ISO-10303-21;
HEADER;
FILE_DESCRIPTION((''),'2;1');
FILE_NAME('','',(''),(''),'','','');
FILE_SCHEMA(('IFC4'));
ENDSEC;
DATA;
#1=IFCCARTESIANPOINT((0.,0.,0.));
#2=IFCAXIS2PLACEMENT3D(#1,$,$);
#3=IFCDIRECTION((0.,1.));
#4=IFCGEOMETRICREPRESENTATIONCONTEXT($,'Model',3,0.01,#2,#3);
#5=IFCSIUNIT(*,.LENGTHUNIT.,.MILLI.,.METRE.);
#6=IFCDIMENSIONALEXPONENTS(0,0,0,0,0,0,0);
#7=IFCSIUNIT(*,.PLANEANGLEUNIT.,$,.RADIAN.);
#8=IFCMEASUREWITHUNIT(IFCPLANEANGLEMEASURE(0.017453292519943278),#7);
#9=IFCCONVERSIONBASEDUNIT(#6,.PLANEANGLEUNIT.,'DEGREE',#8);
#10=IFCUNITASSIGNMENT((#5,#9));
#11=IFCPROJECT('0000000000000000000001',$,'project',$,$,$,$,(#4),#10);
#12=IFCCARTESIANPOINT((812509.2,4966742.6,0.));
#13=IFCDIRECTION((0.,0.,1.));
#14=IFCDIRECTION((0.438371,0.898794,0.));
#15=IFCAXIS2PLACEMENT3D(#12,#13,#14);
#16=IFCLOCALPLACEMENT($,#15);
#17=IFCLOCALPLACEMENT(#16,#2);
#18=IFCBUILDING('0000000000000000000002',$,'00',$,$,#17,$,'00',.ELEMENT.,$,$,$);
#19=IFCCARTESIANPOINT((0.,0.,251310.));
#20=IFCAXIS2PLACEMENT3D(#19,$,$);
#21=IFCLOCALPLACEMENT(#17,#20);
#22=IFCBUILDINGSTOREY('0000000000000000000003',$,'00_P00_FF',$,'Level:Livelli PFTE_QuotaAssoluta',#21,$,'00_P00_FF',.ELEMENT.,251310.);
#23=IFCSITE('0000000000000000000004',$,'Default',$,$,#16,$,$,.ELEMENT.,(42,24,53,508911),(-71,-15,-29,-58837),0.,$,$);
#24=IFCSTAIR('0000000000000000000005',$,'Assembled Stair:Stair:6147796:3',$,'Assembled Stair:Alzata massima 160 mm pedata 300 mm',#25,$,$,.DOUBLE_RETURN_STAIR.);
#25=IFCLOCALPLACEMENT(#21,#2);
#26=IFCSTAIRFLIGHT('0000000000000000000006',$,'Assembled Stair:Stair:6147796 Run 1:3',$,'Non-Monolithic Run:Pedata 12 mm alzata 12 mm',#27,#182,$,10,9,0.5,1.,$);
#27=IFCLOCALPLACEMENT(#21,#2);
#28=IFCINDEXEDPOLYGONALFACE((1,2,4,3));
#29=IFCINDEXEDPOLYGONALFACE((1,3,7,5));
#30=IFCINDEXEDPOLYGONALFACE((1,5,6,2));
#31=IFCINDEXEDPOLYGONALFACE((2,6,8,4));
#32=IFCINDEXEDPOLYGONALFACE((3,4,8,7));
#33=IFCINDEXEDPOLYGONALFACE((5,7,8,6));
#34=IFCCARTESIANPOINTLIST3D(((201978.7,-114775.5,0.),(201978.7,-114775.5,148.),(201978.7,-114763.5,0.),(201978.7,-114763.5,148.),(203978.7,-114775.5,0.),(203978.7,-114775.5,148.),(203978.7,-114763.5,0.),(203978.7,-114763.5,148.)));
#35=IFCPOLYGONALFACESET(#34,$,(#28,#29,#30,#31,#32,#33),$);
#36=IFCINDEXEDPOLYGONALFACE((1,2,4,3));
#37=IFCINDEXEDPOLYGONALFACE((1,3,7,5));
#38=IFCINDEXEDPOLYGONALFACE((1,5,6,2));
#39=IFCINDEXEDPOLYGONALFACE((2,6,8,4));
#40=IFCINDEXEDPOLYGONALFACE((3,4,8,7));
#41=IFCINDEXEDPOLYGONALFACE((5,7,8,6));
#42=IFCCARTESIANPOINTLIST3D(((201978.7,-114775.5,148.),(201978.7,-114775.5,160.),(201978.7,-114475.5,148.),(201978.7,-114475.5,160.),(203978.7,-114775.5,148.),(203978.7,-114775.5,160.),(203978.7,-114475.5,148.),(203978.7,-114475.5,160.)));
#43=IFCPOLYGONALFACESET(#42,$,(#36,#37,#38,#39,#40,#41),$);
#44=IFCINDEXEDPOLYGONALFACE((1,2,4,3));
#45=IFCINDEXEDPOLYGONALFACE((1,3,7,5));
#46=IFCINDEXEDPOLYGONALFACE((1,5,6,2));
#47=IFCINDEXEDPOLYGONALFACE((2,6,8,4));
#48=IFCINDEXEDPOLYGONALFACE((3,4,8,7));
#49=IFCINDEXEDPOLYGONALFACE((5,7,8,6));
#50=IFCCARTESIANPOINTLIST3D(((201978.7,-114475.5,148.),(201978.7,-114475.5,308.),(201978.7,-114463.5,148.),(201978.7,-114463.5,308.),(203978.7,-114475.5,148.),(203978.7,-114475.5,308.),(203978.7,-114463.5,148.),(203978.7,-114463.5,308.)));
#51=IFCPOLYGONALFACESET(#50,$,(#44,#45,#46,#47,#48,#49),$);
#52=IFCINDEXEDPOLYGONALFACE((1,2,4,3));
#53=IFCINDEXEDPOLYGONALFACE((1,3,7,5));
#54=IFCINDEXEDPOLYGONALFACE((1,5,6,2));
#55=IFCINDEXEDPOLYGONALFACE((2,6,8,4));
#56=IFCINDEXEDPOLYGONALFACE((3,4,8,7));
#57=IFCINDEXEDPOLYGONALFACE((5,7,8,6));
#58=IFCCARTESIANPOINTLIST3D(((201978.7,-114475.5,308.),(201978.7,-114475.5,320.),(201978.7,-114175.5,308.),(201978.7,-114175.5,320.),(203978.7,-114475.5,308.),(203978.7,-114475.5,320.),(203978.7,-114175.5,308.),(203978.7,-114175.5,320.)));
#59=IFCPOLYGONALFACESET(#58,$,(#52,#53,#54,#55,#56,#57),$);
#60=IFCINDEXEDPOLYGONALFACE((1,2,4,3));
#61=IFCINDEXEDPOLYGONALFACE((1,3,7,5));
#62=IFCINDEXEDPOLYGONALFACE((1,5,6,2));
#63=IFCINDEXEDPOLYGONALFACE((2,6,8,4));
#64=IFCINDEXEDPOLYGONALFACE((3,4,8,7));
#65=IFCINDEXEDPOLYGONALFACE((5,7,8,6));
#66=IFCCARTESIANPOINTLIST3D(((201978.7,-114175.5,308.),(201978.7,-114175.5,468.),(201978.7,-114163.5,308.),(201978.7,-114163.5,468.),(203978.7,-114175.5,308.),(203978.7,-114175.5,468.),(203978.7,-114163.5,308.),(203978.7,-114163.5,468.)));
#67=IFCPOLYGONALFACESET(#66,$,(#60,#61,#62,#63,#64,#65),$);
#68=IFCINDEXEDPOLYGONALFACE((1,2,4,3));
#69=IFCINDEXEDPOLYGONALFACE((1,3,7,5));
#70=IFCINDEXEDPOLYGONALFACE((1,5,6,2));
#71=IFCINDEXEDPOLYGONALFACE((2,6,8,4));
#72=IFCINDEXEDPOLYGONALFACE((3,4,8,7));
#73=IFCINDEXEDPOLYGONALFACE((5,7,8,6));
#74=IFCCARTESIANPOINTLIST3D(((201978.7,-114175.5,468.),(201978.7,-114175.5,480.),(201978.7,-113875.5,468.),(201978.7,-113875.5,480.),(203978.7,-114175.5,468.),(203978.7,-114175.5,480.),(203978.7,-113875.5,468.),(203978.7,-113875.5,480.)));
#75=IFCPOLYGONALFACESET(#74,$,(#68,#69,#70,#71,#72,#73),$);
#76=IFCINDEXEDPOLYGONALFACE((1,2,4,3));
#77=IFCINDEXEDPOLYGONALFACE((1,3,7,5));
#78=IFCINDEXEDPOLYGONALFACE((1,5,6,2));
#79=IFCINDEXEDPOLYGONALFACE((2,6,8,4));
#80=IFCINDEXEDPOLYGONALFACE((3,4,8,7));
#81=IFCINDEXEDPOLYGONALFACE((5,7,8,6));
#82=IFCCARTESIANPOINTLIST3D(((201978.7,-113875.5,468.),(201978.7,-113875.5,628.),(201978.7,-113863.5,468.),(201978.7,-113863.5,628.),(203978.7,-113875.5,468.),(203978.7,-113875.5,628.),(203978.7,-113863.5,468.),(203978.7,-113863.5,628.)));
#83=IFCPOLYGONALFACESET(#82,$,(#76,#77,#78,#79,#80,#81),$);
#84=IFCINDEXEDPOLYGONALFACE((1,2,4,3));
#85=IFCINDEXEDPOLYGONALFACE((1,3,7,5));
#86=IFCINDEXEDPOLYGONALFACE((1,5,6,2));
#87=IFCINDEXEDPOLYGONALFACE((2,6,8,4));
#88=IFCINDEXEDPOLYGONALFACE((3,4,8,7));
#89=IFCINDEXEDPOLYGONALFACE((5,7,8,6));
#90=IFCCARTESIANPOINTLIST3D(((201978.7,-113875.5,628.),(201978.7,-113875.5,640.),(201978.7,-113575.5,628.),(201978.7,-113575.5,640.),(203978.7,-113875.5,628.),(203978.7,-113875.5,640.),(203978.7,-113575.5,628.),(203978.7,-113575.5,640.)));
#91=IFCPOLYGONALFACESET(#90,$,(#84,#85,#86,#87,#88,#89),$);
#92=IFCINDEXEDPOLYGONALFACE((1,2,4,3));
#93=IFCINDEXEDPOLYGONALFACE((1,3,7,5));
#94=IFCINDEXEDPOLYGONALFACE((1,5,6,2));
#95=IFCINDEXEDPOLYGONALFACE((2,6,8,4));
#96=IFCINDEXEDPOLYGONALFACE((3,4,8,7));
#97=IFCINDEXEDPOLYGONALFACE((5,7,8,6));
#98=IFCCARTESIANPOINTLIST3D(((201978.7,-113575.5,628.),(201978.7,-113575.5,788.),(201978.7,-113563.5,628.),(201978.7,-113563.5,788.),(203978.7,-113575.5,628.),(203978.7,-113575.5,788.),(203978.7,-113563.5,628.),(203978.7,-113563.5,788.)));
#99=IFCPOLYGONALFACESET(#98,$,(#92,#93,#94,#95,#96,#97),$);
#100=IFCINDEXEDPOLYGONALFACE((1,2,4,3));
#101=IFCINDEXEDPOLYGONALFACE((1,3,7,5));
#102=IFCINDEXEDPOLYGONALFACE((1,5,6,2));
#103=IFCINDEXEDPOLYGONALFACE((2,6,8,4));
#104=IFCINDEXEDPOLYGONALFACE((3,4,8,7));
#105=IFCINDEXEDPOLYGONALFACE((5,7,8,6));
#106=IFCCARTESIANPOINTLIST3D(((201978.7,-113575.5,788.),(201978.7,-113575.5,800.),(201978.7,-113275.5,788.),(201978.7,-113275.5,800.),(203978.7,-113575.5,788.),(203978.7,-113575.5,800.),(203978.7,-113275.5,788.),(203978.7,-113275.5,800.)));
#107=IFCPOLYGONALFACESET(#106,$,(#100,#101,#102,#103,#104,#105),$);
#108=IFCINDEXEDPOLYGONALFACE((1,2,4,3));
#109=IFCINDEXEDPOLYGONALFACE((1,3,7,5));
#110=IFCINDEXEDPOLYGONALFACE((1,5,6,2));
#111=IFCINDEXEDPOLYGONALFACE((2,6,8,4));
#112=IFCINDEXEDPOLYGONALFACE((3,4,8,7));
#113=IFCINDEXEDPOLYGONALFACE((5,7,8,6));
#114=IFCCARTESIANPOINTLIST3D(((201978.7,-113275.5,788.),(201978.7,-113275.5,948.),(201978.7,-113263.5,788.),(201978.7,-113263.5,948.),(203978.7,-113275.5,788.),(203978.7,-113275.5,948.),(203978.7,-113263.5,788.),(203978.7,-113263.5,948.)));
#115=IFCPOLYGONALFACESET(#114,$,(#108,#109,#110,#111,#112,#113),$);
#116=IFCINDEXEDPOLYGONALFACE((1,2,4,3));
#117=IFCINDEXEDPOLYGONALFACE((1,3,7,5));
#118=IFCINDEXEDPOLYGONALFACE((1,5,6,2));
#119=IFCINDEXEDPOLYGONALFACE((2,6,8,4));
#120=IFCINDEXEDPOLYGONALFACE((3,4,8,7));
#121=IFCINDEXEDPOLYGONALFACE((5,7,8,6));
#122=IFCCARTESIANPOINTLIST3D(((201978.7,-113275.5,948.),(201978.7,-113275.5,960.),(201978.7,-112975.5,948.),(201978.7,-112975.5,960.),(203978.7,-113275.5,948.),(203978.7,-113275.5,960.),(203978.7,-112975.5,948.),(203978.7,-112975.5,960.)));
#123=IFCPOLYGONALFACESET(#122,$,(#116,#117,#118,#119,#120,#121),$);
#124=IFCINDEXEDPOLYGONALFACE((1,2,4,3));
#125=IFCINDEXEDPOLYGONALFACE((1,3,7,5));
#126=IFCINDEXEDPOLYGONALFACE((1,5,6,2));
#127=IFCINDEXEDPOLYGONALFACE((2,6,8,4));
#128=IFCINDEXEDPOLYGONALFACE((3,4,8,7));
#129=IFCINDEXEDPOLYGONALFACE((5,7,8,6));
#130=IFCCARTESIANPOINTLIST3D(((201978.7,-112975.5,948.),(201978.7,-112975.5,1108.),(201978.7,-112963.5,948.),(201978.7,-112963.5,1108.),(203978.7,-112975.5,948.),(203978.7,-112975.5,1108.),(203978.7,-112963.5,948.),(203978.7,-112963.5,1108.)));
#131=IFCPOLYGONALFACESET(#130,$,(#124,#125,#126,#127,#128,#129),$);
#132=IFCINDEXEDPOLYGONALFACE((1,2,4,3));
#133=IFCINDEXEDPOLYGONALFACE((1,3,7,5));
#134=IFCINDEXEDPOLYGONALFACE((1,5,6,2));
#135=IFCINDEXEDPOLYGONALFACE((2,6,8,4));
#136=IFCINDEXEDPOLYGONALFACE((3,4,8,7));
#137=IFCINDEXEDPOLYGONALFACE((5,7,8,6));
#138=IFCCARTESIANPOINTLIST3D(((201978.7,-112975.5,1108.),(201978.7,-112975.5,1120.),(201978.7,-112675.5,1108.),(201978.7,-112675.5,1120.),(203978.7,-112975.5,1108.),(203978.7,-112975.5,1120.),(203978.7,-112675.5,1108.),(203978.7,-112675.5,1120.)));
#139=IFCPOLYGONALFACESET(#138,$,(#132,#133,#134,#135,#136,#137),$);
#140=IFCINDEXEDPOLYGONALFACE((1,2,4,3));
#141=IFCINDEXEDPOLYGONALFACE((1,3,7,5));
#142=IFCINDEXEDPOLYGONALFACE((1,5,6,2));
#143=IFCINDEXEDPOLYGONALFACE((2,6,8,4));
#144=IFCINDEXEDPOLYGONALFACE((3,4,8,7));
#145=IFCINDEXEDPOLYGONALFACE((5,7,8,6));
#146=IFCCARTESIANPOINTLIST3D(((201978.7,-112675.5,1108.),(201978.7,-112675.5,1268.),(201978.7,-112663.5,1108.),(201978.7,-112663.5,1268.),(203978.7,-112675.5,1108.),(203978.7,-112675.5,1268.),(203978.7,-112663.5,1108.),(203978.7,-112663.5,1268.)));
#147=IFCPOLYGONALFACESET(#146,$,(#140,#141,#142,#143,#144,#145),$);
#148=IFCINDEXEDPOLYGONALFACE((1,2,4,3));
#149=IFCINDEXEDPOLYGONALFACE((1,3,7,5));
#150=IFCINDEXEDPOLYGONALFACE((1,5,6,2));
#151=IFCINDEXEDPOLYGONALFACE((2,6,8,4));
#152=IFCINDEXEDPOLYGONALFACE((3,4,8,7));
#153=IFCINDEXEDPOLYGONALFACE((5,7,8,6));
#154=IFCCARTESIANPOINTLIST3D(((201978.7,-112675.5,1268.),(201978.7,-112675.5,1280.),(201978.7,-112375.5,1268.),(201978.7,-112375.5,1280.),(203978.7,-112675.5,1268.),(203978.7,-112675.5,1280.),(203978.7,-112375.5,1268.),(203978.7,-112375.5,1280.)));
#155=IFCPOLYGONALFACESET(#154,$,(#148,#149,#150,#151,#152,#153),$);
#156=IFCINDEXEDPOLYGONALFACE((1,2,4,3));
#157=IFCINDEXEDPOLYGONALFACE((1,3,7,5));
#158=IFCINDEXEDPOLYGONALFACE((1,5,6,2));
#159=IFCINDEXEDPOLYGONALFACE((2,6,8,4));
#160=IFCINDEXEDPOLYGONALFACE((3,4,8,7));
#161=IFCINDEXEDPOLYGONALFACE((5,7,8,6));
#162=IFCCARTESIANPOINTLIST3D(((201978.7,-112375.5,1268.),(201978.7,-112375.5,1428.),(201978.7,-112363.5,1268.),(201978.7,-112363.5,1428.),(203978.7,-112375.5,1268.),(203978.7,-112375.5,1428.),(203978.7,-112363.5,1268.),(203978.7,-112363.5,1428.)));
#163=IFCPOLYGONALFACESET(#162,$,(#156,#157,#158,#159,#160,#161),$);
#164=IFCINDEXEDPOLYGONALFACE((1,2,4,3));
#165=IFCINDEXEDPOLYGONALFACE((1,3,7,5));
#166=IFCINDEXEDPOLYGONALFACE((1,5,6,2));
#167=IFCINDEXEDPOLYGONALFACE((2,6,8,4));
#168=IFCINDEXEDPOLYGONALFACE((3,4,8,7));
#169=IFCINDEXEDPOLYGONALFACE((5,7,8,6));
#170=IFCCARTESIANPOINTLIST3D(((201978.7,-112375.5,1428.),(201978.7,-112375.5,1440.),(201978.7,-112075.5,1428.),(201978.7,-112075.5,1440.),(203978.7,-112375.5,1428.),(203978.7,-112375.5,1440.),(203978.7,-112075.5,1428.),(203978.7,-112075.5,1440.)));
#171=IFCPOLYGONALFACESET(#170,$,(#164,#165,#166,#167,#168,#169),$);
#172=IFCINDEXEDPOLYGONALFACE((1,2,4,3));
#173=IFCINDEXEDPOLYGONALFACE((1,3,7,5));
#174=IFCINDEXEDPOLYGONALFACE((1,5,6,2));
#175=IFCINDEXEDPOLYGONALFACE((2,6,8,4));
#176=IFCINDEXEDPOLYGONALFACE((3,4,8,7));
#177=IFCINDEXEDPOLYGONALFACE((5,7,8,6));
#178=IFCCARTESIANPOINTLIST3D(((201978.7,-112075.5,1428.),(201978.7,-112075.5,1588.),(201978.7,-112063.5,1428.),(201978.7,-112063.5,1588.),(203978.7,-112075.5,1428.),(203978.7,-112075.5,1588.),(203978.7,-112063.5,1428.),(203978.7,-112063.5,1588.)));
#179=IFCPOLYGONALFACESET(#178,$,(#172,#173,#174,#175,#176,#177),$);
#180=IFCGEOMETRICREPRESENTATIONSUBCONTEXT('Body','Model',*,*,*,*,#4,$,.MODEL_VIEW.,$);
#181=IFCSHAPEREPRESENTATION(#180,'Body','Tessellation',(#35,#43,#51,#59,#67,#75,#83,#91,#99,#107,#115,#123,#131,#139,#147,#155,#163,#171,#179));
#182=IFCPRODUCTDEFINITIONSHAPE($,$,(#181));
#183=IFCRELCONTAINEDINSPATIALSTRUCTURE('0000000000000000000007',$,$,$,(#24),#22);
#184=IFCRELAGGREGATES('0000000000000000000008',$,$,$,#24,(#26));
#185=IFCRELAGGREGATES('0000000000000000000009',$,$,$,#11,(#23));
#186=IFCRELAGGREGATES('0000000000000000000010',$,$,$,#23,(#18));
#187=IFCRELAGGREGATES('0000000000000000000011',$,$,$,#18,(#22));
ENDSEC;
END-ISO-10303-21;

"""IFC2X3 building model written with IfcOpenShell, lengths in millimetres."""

from ifc_helpers import new_model, entity, si_unit, converted_unit, direction, frame, frame_2d, origin, origin_2d_with_axis, place, context, subcontext, project, spatial, rectangle, extrude, element, aggregate, save


model = new_model("IFC2X3")

# Units and contexts
model_context = context("Model", 3, precision=0.01, world=origin(), true_north=direction((0.0, 1.0)))
body_context = subcontext(model_context, "Body", "Model", "MODEL_VIEW")
ifc_project = project(units=[si_unit("LENGTHUNIT", "METRE", prefix="MILLI"), converted_unit("PLANEANGLEUNIT", "DEGREE", entity("IfcPlaneAngleMeasure", 0.017453292519943278), si_unit("PLANEANGLEUNIT", "RADIAN"), dimensions=[0, 0, 0, 0, 0, 0, 0])], contexts=[model_context])

# Site, building, storey
site_placement = place(None, frame((812509.2, 4966742.6, 0.0), z_axis=(0.0, 0.0, 1.0), x_axis=(0.438371, 0.898794, 0.0)))
site = spatial("IfcSite", under=ifc_project, at=site_placement, Name="Default", CompositionType="ELEMENT", RefLatitude=(42, 24, 53, 508911), RefLongitude=(-71, -15, -29, -58837), RefElevation=0.0)
building_placement = place(site_placement, origin())
building = spatial("IfcBuilding", under=site, at=building_placement, Name="00", LongName="00", CompositionType="ELEMENT")
storey_placement = place(building_placement, frame((0.0, 0.0, 251310.0)))
storey = spatial("IfcBuildingStorey", under=building, at=storey_placement, Name="00_P00_FF", ObjectType="Level:Livelli PFTE_QuotaAssoluta", LongName="00_P00_FF", CompositionType="ELEMENT", Elevation=251310.0)

# Stair
stair_1_placement = place(storey_placement, origin())
stair_1 = element("IfcStair", 1, at=stair_1_placement, inside=storey, Name="Assembled Stair:Stair:6147796:3", ObjectType="Assembled Stair:Alzata massima 160 mm pedata 300 mm", ShapeType="DOUBLE_RETURN_STAIR")

# Stair flight
stair_flight_1_placement = place(stair_1_placement, origin())
stair_flight_1 = element("IfcStairFlight", 2, at=stair_flight_1_placement, Name="Assembled Stair:Stair:6147796 Run 1:3", ObjectType="Non-Monolithic Run:Pedata 12 mm alzata 12 mm", NumberOfRiser=10, NumberOfTreads=9, RiserHeight=0.5, TreadLength=1.0, context=body_context, shape_type="SweptSolid", body=[
    extrude(rectangle(XDim=2000.0, YDim=12.0, at=origin_2d_with_axis()), frame((202978.7, -114769.5, 0.0), z_axis=(0.0, 0.0, 1.0), x_axis=(-1.0, 0.0, 0.0)), (0.0, 0.0, 1.0), 148.0),
    extrude(rectangle(XDim=300.0, YDim=2000.0, at=frame_2d((0.0, 0.0), x_axis=(1.0, 0.0))), frame((202978.7, -114625.5, 148.0), z_axis=(0.0, 0.0, 1.0), x_axis=(0.0, -1.0, 0.0)), (0.0, 0.0, 1.0), 12.0),
    extrude(rectangle(XDim=2000.0, YDim=12.0, at=frame_2d((0.0, 0.0), x_axis=(1.0, 0.0))), frame((202978.7, -114469.5, 148.0), z_axis=(0.0, 0.0, 1.0), x_axis=(-1.0, 0.0, 0.0)), (0.0, 0.0, 1.0), 160.0),
    extrude(rectangle(XDim=300.0, YDim=2000.0, at=frame_2d((0.0, 0.0), x_axis=(1.0, 0.0))), frame((202978.7, -114325.5, 308.0), z_axis=(0.0, 0.0, 1.0), x_axis=(0.0, -1.0, 0.0)), (0.0, 0.0, 1.0), 12.0),
    extrude(rectangle(XDim=2000.0, YDim=12.0, at=frame_2d((0.0, 0.0), x_axis=(1.0, 0.0))), frame((202978.7, -114169.5, 308.0), z_axis=(0.0, 0.0, 1.0), x_axis=(-1.0, 0.0, 0.0)), (0.0, 0.0, 1.0), 160.0),
    extrude(rectangle(XDim=300.0, YDim=2000.0, at=frame_2d((0.0, 0.0), x_axis=(1.0, 0.0))), frame((202978.7, -114025.5, 468.0), z_axis=(0.0, 0.0, 1.0), x_axis=(0.0, -1.0, 0.0)), (0.0, 0.0, 1.0), 12.0),
    extrude(rectangle(XDim=2000.0, YDim=12.0, at=frame_2d((0.0, 0.0), x_axis=(1.0, 0.0))), frame((202978.7, -113869.5, 468.0), z_axis=(0.0, 0.0, 1.0), x_axis=(-1.0, 0.0, 0.0)), (0.0, 0.0, 1.0), 160.0),
    extrude(rectangle(XDim=300.0, YDim=2000.0, at=frame_2d((0.0, 0.0), x_axis=(1.0, 0.0))), frame((202978.7, -113725.5, 628.0), z_axis=(0.0, 0.0, 1.0), x_axis=(0.0, -1.0, 0.0)), (0.0, 0.0, 1.0), 12.0),
    extrude(rectangle(XDim=2000.0, YDim=12.0, at=frame_2d((0.0, 0.0), x_axis=(1.0, 0.0))), frame((202978.7, -113569.5, 628.0), z_axis=(0.0, 0.0, 1.0), x_axis=(-1.0, 0.0, 0.0)), (0.0, 0.0, 1.0), 160.0),
    extrude(rectangle(XDim=300.0, YDim=2000.0, at=frame_2d((0.0, 0.0), x_axis=(1.0, 0.0))), frame((202978.7, -113425.5, 788.0), z_axis=(0.0, 0.0, 1.0), x_axis=(0.0, -1.0, 0.0)), (0.0, 0.0, 1.0), 12.0),
    extrude(rectangle(XDim=2000.0, YDim=12.0, at=frame_2d((0.0, 0.0), x_axis=(1.0, 0.0))), frame((202978.7, -113269.5, 788.0), z_axis=(0.0, 0.0, 1.0), x_axis=(-1.0, 0.0, 0.0)), (0.0, 0.0, 1.0), 160.0),
    extrude(rectangle(XDim=300.0, YDim=2000.0, at=frame_2d((0.0, 0.0), x_axis=(1.0, 0.0))), frame((202978.7, -113125.5, 948.0), z_axis=(0.0, 0.0, 1.0), x_axis=(0.0, -1.0, 0.0)), (0.0, 0.0, 1.0), 12.0),
    extrude(rectangle(XDim=2000.0, YDim=12.0, at=frame_2d((0.0, 0.0), x_axis=(1.0, 0.0))), frame((202978.7, -112969.5, 948.0), z_axis=(0.0, 0.0, 1.0), x_axis=(-1.0, 0.0, 0.0)), (0.0, 0.0, 1.0), 160.0),
    extrude(rectangle(XDim=300.0, YDim=2000.0, at=frame_2d((0.0, 0.0), x_axis=(1.0, 0.0))), frame((202978.7, -112825.5, 1108.0), z_axis=(0.0, 0.0, 1.0), x_axis=(0.0, -1.0, 0.0)), (0.0, 0.0, 1.0), 12.0),
    extrude(rectangle(XDim=2000.0, YDim=12.0, at=frame_2d((0.0, 0.0), x_axis=(1.0, 0.0))), frame((202978.7, -112669.5, 1108.0), z_axis=(0.0, 0.0, 1.0), x_axis=(-1.0, 0.0, 0.0)), (0.0, 0.0, 1.0), 160.0),
    extrude(rectangle(XDim=300.0, YDim=2000.0, at=frame_2d((0.0, 0.0), x_axis=(1.0, 0.0))), frame((202978.7, -112525.5, 1268.0), z_axis=(0.0, 0.0, 1.0), x_axis=(0.0, -1.0, 0.0)), (0.0, 0.0, 1.0), 12.0),
    extrude(rectangle(XDim=2000.0, YDim=12.0, at=frame_2d((0.0, 0.0), x_axis=(1.0, 0.0))), frame((202978.7, -112369.5, 1268.0), z_axis=(0.0, 0.0, 1.0), x_axis=(-1.0, 0.0, 0.0)), (0.0, 0.0, 1.0), 160.0),
    extrude(rectangle(XDim=300.0, YDim=2000.0, at=frame_2d((0.0, 0.0), x_axis=(1.0, 0.0))), frame((202978.7, -112225.5, 1428.0), z_axis=(0.0, 0.0, 1.0), x_axis=(0.0, -1.0, 0.0)), (0.0, 0.0, 1.0), 12.0),
    extrude(rectangle(XDim=2000.0, YDim=12.0, at=origin_2d_with_axis()), frame((202978.7, -112069.5, 1428.0), z_axis=(0.0, 0.0, 1.0), x_axis=(-1.0, 0.0, 0.0)), (0.0, 0.0, 1.0), 160.0),
])
aggregate(stair_1, [stair_flight_1])

save(model, "model.ifc")
